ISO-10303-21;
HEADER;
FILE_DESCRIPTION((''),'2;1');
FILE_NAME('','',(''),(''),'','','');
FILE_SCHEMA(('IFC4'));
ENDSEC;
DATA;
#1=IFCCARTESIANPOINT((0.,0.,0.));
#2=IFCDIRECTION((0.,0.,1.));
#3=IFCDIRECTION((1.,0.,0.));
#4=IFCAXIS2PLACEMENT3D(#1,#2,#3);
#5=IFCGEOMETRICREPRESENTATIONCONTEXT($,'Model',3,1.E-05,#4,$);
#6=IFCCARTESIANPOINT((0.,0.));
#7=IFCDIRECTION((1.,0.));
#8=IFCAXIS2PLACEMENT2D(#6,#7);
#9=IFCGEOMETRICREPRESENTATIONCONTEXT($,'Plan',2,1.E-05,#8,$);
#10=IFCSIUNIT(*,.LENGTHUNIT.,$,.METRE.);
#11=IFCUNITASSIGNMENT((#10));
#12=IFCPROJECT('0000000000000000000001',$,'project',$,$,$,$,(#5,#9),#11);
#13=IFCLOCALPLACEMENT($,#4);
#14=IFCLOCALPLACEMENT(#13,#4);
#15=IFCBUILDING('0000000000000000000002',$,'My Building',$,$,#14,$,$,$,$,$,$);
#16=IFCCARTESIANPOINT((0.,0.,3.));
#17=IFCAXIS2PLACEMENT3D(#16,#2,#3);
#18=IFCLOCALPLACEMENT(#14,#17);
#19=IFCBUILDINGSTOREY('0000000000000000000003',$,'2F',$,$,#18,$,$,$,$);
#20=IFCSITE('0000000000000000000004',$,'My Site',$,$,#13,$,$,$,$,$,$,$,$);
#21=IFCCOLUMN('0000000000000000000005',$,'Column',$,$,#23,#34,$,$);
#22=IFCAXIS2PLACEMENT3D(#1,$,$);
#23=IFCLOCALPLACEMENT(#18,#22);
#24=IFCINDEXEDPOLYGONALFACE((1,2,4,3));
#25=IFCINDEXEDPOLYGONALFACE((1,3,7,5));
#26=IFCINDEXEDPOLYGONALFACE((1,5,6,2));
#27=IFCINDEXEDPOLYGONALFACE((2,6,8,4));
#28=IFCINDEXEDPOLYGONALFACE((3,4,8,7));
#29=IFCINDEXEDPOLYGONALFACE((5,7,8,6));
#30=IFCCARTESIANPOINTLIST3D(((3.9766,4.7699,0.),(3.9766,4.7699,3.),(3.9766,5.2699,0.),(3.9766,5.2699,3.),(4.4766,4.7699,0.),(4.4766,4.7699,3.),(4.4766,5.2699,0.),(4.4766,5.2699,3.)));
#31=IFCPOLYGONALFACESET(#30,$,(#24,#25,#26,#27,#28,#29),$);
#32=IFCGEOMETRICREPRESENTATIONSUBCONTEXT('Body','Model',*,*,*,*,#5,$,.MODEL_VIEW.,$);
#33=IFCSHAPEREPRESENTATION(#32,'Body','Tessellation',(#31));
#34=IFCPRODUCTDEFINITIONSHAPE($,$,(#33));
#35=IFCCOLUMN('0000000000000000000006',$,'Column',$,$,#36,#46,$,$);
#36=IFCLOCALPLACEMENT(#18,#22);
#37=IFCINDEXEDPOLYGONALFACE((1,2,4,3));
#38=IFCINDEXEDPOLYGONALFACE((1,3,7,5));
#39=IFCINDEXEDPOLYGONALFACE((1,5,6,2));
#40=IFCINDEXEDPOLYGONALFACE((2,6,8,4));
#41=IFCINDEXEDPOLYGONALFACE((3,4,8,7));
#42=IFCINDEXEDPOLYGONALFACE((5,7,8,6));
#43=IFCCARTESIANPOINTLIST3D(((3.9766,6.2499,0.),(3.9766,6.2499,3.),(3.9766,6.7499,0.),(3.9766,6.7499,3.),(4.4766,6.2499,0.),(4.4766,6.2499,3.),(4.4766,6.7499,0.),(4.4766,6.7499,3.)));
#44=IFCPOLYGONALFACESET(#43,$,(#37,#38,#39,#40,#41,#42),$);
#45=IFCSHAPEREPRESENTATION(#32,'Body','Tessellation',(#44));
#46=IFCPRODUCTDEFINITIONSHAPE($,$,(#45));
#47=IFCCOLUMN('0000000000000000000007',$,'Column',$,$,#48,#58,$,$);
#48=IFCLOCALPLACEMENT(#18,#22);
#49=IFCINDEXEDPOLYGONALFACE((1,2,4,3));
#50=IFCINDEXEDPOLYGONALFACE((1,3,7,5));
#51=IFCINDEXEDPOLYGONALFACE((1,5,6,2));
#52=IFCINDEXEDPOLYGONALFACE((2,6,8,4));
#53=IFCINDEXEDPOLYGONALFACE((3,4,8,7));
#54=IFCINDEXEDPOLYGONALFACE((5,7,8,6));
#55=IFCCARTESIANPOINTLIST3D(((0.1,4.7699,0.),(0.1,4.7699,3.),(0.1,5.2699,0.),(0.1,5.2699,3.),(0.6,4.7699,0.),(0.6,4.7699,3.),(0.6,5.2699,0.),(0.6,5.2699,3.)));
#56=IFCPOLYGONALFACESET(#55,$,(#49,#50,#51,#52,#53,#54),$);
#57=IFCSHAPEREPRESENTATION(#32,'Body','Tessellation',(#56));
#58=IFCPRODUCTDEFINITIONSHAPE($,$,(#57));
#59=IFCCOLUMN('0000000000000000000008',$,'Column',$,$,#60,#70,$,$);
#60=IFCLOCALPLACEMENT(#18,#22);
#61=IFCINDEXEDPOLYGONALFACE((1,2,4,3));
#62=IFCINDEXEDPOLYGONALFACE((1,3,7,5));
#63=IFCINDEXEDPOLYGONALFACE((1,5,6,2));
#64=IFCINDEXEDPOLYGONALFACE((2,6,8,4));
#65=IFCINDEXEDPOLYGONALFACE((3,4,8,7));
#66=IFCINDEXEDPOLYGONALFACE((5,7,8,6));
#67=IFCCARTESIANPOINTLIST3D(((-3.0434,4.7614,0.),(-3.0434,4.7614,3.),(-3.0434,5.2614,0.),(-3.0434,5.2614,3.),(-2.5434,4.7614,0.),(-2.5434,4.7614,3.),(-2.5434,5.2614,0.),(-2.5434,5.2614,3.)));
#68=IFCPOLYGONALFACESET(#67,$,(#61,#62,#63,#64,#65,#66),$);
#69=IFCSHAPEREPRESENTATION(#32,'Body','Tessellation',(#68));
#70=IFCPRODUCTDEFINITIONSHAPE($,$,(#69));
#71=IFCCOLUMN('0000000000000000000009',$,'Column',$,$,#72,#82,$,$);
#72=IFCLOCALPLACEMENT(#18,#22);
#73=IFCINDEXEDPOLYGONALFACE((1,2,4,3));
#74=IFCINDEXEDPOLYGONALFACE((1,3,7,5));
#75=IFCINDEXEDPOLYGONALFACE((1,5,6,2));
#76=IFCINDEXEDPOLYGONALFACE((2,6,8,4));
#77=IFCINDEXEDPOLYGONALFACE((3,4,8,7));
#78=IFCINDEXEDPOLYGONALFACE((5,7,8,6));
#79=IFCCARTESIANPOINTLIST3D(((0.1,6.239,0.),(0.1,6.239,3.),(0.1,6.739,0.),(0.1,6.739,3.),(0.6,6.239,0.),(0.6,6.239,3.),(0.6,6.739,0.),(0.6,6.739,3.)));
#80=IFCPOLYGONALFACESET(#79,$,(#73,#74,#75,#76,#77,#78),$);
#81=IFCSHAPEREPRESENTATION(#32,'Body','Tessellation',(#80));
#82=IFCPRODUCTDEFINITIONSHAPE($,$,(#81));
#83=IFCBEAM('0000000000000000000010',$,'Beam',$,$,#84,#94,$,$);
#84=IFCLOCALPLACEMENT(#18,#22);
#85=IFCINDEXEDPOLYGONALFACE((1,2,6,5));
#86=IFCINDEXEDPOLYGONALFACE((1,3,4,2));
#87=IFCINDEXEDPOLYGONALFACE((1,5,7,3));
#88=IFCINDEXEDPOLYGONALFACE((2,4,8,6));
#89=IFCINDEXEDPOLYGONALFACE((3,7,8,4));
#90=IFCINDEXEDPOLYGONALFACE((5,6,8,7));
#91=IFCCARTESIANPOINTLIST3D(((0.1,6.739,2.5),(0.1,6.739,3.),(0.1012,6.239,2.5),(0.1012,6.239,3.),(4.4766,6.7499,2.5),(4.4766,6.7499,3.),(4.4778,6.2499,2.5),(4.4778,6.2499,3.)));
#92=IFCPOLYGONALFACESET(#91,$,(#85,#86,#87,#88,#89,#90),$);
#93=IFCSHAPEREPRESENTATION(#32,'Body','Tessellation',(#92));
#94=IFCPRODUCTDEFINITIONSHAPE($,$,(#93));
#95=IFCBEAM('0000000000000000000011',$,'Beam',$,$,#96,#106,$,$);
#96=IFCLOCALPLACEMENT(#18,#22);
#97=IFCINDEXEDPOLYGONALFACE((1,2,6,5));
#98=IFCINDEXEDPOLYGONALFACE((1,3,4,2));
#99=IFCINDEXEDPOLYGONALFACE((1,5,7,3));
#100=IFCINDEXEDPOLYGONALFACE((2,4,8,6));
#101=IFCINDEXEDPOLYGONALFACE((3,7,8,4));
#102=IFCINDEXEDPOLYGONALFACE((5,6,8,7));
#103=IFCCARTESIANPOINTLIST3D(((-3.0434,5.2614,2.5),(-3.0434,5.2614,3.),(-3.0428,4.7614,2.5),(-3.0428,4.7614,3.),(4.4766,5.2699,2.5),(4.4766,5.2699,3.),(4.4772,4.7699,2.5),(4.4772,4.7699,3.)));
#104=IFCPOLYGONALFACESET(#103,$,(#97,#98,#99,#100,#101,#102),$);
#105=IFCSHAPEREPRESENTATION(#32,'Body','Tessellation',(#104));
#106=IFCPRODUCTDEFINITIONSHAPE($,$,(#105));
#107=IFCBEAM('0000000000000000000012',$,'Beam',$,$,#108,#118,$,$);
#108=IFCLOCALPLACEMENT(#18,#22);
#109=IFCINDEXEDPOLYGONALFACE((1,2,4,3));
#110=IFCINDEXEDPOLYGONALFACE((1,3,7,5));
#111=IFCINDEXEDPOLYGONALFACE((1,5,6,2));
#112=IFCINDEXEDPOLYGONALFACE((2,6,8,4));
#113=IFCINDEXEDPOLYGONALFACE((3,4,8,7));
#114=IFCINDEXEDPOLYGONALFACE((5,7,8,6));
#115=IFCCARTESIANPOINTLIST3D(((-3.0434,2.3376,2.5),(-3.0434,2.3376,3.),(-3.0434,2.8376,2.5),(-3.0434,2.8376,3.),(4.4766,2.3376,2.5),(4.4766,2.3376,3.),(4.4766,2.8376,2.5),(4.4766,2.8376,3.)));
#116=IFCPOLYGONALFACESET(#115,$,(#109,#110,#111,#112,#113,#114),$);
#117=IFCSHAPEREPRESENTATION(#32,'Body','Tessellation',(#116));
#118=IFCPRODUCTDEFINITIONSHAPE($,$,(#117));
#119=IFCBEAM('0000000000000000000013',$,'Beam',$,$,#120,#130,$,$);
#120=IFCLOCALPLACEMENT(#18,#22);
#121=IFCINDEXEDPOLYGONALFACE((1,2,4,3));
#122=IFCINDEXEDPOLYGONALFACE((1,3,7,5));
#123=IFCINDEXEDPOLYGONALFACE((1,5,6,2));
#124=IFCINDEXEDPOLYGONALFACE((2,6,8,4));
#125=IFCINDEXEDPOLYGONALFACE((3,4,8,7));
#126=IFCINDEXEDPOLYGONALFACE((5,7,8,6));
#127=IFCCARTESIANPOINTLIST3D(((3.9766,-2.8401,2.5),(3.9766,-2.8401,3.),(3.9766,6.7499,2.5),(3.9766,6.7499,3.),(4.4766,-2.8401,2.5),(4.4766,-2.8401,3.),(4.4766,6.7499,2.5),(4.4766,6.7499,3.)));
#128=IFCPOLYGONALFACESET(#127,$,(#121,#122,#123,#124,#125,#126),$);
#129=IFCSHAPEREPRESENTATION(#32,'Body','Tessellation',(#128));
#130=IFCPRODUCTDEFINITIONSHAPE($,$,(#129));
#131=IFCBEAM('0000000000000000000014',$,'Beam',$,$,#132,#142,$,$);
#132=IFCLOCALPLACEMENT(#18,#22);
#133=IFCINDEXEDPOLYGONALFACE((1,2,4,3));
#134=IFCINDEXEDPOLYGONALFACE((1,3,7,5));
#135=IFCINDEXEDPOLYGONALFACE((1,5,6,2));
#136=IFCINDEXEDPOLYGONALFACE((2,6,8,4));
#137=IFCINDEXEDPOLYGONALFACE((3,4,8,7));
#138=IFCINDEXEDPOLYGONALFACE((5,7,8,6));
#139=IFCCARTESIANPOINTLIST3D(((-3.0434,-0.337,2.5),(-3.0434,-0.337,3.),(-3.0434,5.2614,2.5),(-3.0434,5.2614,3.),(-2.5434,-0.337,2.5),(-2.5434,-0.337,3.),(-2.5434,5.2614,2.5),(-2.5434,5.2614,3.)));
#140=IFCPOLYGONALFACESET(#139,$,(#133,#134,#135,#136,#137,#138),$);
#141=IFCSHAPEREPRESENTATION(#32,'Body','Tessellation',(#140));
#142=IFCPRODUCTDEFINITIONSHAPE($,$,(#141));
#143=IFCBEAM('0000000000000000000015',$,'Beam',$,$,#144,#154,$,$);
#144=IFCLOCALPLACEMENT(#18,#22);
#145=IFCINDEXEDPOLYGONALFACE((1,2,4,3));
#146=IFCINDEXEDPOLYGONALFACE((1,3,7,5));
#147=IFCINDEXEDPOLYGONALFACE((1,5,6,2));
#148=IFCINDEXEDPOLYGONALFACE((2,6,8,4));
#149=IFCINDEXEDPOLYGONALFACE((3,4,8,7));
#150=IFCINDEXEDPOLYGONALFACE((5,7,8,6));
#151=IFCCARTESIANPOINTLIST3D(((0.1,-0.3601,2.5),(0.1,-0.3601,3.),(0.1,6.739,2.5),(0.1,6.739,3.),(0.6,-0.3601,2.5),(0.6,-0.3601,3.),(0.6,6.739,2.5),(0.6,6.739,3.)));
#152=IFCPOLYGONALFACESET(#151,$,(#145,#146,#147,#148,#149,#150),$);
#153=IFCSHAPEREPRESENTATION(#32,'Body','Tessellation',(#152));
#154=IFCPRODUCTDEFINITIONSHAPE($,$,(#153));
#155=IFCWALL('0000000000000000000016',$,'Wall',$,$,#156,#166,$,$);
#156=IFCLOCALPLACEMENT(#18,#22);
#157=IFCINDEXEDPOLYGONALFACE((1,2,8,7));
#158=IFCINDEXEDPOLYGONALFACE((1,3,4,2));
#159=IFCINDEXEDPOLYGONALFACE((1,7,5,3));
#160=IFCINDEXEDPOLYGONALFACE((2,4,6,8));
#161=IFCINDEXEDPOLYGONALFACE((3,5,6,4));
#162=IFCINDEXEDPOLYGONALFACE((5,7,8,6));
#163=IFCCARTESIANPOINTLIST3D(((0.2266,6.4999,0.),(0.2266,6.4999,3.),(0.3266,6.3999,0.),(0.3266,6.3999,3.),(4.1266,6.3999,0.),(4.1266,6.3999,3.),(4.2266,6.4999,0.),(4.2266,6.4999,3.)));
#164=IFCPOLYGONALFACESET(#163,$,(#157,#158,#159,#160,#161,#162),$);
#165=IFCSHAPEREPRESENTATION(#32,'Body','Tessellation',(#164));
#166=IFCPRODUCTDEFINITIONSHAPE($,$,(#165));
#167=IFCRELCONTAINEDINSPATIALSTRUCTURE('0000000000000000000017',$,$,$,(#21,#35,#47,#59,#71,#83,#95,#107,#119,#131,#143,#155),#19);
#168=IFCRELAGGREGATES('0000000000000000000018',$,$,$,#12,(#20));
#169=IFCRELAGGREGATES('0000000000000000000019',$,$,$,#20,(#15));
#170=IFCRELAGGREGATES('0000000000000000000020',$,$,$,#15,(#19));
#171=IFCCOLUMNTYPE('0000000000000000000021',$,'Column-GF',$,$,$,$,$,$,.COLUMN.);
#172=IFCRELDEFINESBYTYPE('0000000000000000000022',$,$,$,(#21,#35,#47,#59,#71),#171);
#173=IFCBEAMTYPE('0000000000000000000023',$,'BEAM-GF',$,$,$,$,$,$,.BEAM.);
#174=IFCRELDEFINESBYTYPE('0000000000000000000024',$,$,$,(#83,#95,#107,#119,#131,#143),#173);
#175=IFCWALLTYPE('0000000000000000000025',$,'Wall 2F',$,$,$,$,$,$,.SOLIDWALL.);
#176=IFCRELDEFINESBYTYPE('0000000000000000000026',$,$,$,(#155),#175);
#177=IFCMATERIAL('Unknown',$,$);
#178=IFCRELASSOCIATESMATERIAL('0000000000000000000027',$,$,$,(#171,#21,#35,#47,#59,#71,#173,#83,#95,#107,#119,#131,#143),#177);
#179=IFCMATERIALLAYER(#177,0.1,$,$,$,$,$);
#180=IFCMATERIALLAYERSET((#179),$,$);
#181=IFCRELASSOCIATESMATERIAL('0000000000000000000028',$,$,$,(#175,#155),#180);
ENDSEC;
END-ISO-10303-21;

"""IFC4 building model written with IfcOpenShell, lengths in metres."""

from ifc_helpers import new_model, si_unit, frame, origin_with_axes, origin_2d_with_axis, place, context, subcontext, project, spatial, line, indexed_curve, rectangle, outline, extrude, material, layer, layer_set, layer_usage, material_profile, profile_set, profile_usage, type_object, element, save


model = new_model("IFC4")

# Units and contexts
model_context = context("Model", 3, precision=1e-05, world=origin_with_axes())
plan_context = context("Plan", 2, precision=1e-05, world=origin_2d_with_axis())
body_context_1 = subcontext(model_context, "Body", "Model", "MODEL_VIEW")
ifc_project = project(units=[si_unit("LENGTHUNIT", "METRE")], contexts=[model_context, plan_context])

# Site, building, storey
site_placement = place(None, origin_with_axes())
site = spatial("IfcSite", under=ifc_project, at=site_placement, Name="My Site")
building_placement = place(site_placement, origin_with_axes())
building = spatial("IfcBuilding", under=site, at=building_placement, Name="My Building")
storey_placement = place(building_placement, frame((0.0, 0.0, 3.0), z_axis=(0.0, 0.0, 1.0), x_axis=(1.0, 0.0, 0.0)))
storey = spatial("IfcBuildingStorey", under=building, at=storey_placement, Name="2F")

# Columns
ifc_material = material(Name="Unknown")
ifc_material_profile_1 = material_profile(ifc_material, rectangle(XDim=0.5, YDim=0.5))
ifc_profile_set_1 = profile_set([ifc_material_profile_1])
ifc_profile_usage_1 = profile_usage(ifc_profile_set_1, cardinal=7)
column_type = type_object("IfcColumnType", Name="Column-GF", PredefinedType="COLUMN", material=ifc_profile_set_1)
column_1_placement = place(storey_placement, frame((4.4766, 5.2699, 0.0), z_axis=(0.0, 0.0, 1.0), x_axis=(1.0, 0.0, 0.0)))
element("IfcColumn", 1, at=column_1_placement, inside=storey, type_object=column_type, material=ifc_profile_usage_1, Name="Column", context=body_context_1, shape_type="SweptSolid", body=[
    extrude(rectangle(XDim=0.5, YDim=0.5), frame((-0.25, -0.25, 0.0), z_axis=(0.0, 0.0, 1.0), x_axis=(1.0, 0.0, 0.0)), (0.0, 0.0, 1.0), 3.0),
])
ifc_profile_usage_2 = profile_usage(ifc_profile_set_1, cardinal=7)
column_2_placement = place(storey_placement, frame((4.4766, 6.7499, 0.0), z_axis=(0.0, 0.0, 1.0), x_axis=(1.0, 0.0, 0.0)))
element("IfcColumn", 2, at=column_2_placement, inside=storey, type_object=column_type, material=ifc_profile_usage_2, Name="Column", context=body_context_1, shape_type="SweptSolid", body=[
    extrude(rectangle(XDim=0.5, YDim=0.5), frame((-0.25, -0.25, 0.0), z_axis=(0.0, 0.0, 1.0), x_axis=(1.0, 0.0, 0.0)), (0.0, 0.0, 1.0), 3.0),
])
ifc_profile_usage_3 = profile_usage(ifc_profile_set_1, cardinal=7)
column_3_placement = place(storey_placement, frame((0.6, 5.2699, 0.0), z_axis=(0.0, 0.0, 1.0), x_axis=(1.0, 0.0, 0.0)))
element("IfcColumn", 3, at=column_3_placement, inside=storey, type_object=column_type, material=ifc_profile_usage_3, Name="Column", context=body_context_1, shape_type="SweptSolid", body=[
    extrude(rectangle(XDim=0.5, YDim=0.5), frame((-0.25, -0.25, 0.0), z_axis=(0.0, 0.0, 1.0), x_axis=(1.0, 0.0, 0.0)), (0.0, 0.0, 1.0), 3.0),
])
ifc_profile_usage_4 = profile_usage(ifc_profile_set_1, cardinal=7)
column_4_placement = place(storey_placement, frame((-2.5434, 5.2614, 0.0), z_axis=(0.0, 0.0, 1.0), x_axis=(1.0, 0.0, 0.0)))
element("IfcColumn", 4, at=column_4_placement, inside=storey, type_object=column_type, material=ifc_profile_usage_4, Name="Column", context=body_context_1, shape_type="SweptSolid", body=[
    extrude(rectangle(XDim=0.5, YDim=0.5), frame((-0.25, -0.25, 0.0), z_axis=(0.0, 0.0, 1.0), x_axis=(1.0, 0.0, 0.0)), (0.0, 0.0, 1.0), 3.0),
])
ifc_profile_usage_5 = profile_usage(ifc_profile_set_1, cardinal=7)
column_5_placement = place(storey_placement, frame((0.6, 6.739, 0.0), z_axis=(0.0, 0.0, 1.0), x_axis=(1.0, 0.0, 0.0)))
element("IfcColumn", 5, at=column_5_placement, inside=storey, type_object=column_type, material=ifc_profile_usage_5, Name="Column", context=body_context_1, shape_type="SweptSolid", body=[
    extrude(rectangle(XDim=0.5, YDim=0.5), frame((-0.25, -0.25, 0.0), z_axis=(0.0, 0.0, 1.0), x_axis=(1.0, 0.0, 0.0)), (0.0, 0.0, 1.0), 3.0),
])

# Beams
ifc_material_profile_2 = material_profile(ifc_material, rectangle(XDim=0.5, YDim=0.5))
ifc_profile_set_2 = profile_set([ifc_material_profile_2])
ifc_profile_usage_6 = profile_usage(ifc_profile_set_2, cardinal=7)
beam_type = type_object("IfcBeamType", Name="BEAM-GF", PredefinedType="BEAM", material=ifc_profile_set_2)
beam_1_placement = place(storey_placement, frame((0.1, 6.739, 3.0), z_axis=(0.999997, 0.002482, 0.0), x_axis=(-0.002482, 0.999997, 0.0)))
element("IfcBeam", 6, at=beam_1_placement, inside=storey, type_object=beam_type, material=ifc_profile_usage_6, Name="Beam", context=body_context_1, shape_type="SweptSolid", body=[
    extrude(rectangle(XDim=0.5, YDim=0.5), frame((-0.25, -0.25, 0.0), z_axis=(0.0, 0.0, 1.0), x_axis=(1.0, 0.0, 0.0)), (0.0, 0.0, 1.0), 4.3766),
])
ifc_profile_usage_7 = profile_usage(ifc_profile_set_2, cardinal=7)
beam_2_placement = place(storey_placement, frame((-3.0434, 5.2614, 3.0), z_axis=(0.999999, 0.001132, 0.0), x_axis=(-0.001132, 0.999999, 0.0)))
element("IfcBeam", 7, at=beam_2_placement, inside=storey, type_object=beam_type, material=ifc_profile_usage_7, Name="Beam", context=body_context_1, shape_type="SweptSolid", body=[
    extrude(rectangle(XDim=0.5, YDim=0.5), frame((-0.25, -0.25, 0.0), z_axis=(0.0, 0.0, 1.0), x_axis=(1.0, 0.0, 0.0)), (0.0, 0.0, 1.0), 7.52),
])
ifc_profile_usage_8 = profile_usage(ifc_profile_set_2, cardinal=7)
beam_3_placement = place(storey_placement, frame((-3.0434, 2.8376, 3.0), z_axis=(1.0, 0.0, 0.0), x_axis=(0.0, 1.0, 0.0)))
element("IfcBeam", 8, at=beam_3_placement, inside=storey, type_object=beam_type, material=ifc_profile_usage_8, Name="Beam", context=body_context_1, shape_type="SweptSolid", body=[
    extrude(rectangle(XDim=0.5, YDim=0.5), frame((-0.25, -0.25, 0.0), z_axis=(0.0, 0.0, 1.0), x_axis=(1.0, 0.0, 0.0)), (0.0, 0.0, 1.0), 7.52),
])
ifc_profile_usage_9 = profile_usage(ifc_profile_set_2, cardinal=7)
beam_4_placement = place(storey_placement, frame((4.4766, 6.7499, 3.0), z_axis=(-0.000001, -1.0, 0.0), x_axis=(1.0, -0.000001, 0.0)))
element("IfcBeam", 9, at=beam_4_placement, inside=storey, type_object=beam_type, material=ifc_profile_usage_9, Name="Beam", context=body_context_1, shape_type="SweptSolid", body=[
    extrude(rectangle(XDim=0.5, YDim=0.5), frame((-0.25, -0.25, 0.0), z_axis=(0.0, 0.0, 1.0), x_axis=(1.0, 0.0, 0.0)), (0.0, 0.0, 1.0), 9.59),
])
ifc_profile_usage_10 = profile_usage(ifc_profile_set_2, cardinal=7)
beam_5_placement = place(storey_placement, frame((-2.5434, 5.2614, 3.0), z_axis=(0.000001, -1.0, 0.0), x_axis=(1.0, 0.000001, 0.0)))
element("IfcBeam", 10, at=beam_5_placement, inside=storey, type_object=beam_type, material=ifc_profile_usage_10, Name="Beam", context=body_context_1, shape_type="SweptSolid", body=[
    extrude(rectangle(XDim=0.5, YDim=0.5), frame((-0.25, -0.25, 0.0), z_axis=(0.0, 0.0, 1.0), x_axis=(1.0, 0.0, 0.0)), (0.0, 0.0, 1.0), 5.5984),
])
ifc_profile_usage_11 = profile_usage(ifc_profile_set_2, cardinal=7)
beam_6_placement = place(storey_placement, frame((0.6, 6.739, 3.0), z_axis=(0.0, -1.0, 0.0), x_axis=(1.0, 0.0, 0.0)))
element("IfcBeam", 11, at=beam_6_placement, inside=storey, type_object=beam_type, material=ifc_profile_usage_11, Name="Beam", context=body_context_1, shape_type="SweptSolid", body=[
    extrude(rectangle(XDim=0.5, YDim=0.5), frame((-0.25, -0.25, 0.0), z_axis=(0.0, 0.0, 1.0), x_axis=(1.0, 0.0, 0.0)), (0.0, 0.0, 1.0), 7.0991),
])

# Wall
ifc_layer = layer(ifc_material, 0.1)
ifc_layer_set = layer_set([ifc_layer])
ifc_layer_usage_1 = layer_usage(ifc_layer_set, "AXIS2", "POSITIVE", 0.0)
wall_type = type_object("IfcWallType", Name="Wall 2F", PredefinedType="SOLIDWALL", material=ifc_layer_set)
wall_1_placement = place(storey_placement, frame((4.2266, 6.4999, 0.0), z_axis=(0.0, 0.0, 1.0), x_axis=(-1.0, 0.0, 0.0)))
element("IfcWall", 12, at=wall_1_placement, inside=storey, type_object=wall_type, material=ifc_layer_usage_1, Name="Wall", context=body_context_1, shape_type="SweptSolid", body=[
    extrude(outline(indexed_curve([(0.0, 0.0), (0.1, 0.1), (3.9, 0.1), (4.0, 0.0)], segments=[line(1, 2, 3, 4, 1)])), origin_with_axes(), (0.0, 0.0, 1.0), 3.0),
])

save(model, "model.ifc")
